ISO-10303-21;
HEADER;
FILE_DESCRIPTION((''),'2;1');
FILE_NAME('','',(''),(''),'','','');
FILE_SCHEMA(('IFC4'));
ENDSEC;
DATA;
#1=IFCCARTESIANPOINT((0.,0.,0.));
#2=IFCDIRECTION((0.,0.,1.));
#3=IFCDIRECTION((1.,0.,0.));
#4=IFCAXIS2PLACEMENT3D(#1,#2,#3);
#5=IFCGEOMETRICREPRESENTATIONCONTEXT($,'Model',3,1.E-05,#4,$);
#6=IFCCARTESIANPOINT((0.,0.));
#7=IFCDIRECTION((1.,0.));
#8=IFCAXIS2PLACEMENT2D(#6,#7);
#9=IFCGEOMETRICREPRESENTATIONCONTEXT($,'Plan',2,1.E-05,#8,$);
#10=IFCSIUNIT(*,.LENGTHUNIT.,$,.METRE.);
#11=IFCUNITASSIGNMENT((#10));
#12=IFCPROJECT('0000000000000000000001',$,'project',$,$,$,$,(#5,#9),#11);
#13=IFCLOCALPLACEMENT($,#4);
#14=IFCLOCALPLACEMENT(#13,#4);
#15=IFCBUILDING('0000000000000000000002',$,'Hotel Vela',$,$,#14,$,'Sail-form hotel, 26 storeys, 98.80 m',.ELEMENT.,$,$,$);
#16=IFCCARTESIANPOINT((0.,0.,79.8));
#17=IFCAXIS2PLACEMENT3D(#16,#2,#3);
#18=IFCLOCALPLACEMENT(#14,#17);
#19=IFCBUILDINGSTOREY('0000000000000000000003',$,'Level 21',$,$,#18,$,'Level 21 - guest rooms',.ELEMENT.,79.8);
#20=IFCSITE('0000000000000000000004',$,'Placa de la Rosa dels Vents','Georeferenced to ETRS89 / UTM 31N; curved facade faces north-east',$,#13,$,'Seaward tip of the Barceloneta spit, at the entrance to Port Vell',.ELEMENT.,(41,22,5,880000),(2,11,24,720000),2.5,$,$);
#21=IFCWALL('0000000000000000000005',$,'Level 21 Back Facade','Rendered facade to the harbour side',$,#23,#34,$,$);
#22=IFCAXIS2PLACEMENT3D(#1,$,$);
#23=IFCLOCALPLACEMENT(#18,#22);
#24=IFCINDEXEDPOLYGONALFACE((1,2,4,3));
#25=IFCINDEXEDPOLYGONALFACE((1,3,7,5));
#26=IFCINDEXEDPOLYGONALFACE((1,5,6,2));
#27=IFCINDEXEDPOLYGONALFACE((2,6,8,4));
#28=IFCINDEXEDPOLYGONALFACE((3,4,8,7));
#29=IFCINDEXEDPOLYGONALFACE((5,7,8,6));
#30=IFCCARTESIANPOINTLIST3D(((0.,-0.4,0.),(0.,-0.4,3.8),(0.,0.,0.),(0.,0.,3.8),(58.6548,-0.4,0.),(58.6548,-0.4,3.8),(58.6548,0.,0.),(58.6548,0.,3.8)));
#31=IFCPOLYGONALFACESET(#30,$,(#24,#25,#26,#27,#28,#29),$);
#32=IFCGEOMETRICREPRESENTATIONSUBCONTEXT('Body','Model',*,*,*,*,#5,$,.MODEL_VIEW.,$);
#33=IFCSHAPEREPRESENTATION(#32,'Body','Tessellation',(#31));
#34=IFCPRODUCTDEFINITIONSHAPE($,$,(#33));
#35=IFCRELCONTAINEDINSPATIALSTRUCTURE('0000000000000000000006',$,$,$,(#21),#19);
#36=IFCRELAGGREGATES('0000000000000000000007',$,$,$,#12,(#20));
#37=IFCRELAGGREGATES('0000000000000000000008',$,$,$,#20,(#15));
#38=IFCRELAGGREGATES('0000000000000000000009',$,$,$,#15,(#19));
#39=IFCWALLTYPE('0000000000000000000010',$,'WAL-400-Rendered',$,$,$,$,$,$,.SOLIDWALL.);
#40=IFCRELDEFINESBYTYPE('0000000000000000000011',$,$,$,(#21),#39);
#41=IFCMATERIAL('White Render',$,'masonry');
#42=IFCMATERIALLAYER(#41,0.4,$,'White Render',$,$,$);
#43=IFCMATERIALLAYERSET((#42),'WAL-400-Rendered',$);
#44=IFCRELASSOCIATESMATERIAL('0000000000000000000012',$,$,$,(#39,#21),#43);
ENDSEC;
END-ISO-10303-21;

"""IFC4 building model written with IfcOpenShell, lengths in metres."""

from ifc_helpers import new_model, si_unit, frame, origin_with_axes, origin_2d_with_axis, place, context, subcontext, project, spatial, line, indexed_curve, outline, extrude, material, layer, layer_set, layer_usage, type_object, element, save


model = new_model("IFC4")

# Units and contexts
model_context = context("Model", 3, precision=1e-05, world=origin_with_axes())
plan_context = context("Plan", 2, precision=1e-05, world=origin_2d_with_axis())
body_context = subcontext(model_context, "Body", "Model", "MODEL_VIEW")
ifc_project = project(units=[si_unit("LENGTHUNIT", "METRE")], contexts=[model_context, plan_context])

# Site, building, storey
site_placement = place(None, origin_with_axes())
site = spatial("IfcSite", under=ifc_project, at=site_placement, Name="Placa de la Rosa dels Vents", Description="Georeferenced to ETRS89 / UTM 31N; curved facade faces north-east", LongName="Seaward tip of the Barceloneta spit, at the entrance to Port Vell", CompositionType="ELEMENT", RefLatitude=(41, 22, 5, 880000), RefLongitude=(2, 11, 24, 720000), RefElevation=2.5)
building_placement = place(site_placement, origin_with_axes())
building = spatial("IfcBuilding", under=site, at=building_placement, Name="Hotel Vela", LongName="Sail-form hotel, 26 storeys, 98.80 m", CompositionType="ELEMENT")
storey_placement = place(building_placement, frame((0.0, 0.0, 79.8), z_axis=(0.0, 0.0, 1.0), x_axis=(1.0, 0.0, 0.0)))
storey = spatial("IfcBuildingStorey", under=building, at=storey_placement, Name="Level 21", LongName="Level 21 - guest rooms", CompositionType="ELEMENT", Elevation=79.8)

# Wall
ifc_material_1 = material(Name="White Render", Category="masonry")
ifc_layer_1 = layer(ifc_material_1, 0.4, Name="White Render")
ifc_layer_set_1 = layer_set([ifc_layer_1], Name="WAL-400-Rendered")
ifc_layer_usage_1 = layer_usage(ifc_layer_set_1, "AXIS2", "POSITIVE", 0.0)
wall_type = type_object("IfcWallType", Name="WAL-400-Rendered", PredefinedType="SOLIDWALL", material=ifc_layer_set_1)
wall_placement = place(storey_placement, frame((0.0, -0.4, 0.0), z_axis=(0.0, 0.0, 1.0), x_axis=(1.0, 0.0, 0.0)))
element("IfcWall", 1, at=wall_placement, inside=storey, type_object=wall_type, material=ifc_layer_usage_1, Name="Level 21 Back Facade", Description="Rendered facade to the harbour side", context=body_context, shape_type="SweptSolid", body=[
    extrude(outline(indexed_curve([(0.0, 0.0), (58.6548, 0.0), (58.6548, 0.4), (0.0, 0.4)], segments=[line(1, 2, 3, 4, 1)])), origin_with_axes(), (0.0, 0.0, 1.0), 3.8),
])

save(model, "model.ifc")
